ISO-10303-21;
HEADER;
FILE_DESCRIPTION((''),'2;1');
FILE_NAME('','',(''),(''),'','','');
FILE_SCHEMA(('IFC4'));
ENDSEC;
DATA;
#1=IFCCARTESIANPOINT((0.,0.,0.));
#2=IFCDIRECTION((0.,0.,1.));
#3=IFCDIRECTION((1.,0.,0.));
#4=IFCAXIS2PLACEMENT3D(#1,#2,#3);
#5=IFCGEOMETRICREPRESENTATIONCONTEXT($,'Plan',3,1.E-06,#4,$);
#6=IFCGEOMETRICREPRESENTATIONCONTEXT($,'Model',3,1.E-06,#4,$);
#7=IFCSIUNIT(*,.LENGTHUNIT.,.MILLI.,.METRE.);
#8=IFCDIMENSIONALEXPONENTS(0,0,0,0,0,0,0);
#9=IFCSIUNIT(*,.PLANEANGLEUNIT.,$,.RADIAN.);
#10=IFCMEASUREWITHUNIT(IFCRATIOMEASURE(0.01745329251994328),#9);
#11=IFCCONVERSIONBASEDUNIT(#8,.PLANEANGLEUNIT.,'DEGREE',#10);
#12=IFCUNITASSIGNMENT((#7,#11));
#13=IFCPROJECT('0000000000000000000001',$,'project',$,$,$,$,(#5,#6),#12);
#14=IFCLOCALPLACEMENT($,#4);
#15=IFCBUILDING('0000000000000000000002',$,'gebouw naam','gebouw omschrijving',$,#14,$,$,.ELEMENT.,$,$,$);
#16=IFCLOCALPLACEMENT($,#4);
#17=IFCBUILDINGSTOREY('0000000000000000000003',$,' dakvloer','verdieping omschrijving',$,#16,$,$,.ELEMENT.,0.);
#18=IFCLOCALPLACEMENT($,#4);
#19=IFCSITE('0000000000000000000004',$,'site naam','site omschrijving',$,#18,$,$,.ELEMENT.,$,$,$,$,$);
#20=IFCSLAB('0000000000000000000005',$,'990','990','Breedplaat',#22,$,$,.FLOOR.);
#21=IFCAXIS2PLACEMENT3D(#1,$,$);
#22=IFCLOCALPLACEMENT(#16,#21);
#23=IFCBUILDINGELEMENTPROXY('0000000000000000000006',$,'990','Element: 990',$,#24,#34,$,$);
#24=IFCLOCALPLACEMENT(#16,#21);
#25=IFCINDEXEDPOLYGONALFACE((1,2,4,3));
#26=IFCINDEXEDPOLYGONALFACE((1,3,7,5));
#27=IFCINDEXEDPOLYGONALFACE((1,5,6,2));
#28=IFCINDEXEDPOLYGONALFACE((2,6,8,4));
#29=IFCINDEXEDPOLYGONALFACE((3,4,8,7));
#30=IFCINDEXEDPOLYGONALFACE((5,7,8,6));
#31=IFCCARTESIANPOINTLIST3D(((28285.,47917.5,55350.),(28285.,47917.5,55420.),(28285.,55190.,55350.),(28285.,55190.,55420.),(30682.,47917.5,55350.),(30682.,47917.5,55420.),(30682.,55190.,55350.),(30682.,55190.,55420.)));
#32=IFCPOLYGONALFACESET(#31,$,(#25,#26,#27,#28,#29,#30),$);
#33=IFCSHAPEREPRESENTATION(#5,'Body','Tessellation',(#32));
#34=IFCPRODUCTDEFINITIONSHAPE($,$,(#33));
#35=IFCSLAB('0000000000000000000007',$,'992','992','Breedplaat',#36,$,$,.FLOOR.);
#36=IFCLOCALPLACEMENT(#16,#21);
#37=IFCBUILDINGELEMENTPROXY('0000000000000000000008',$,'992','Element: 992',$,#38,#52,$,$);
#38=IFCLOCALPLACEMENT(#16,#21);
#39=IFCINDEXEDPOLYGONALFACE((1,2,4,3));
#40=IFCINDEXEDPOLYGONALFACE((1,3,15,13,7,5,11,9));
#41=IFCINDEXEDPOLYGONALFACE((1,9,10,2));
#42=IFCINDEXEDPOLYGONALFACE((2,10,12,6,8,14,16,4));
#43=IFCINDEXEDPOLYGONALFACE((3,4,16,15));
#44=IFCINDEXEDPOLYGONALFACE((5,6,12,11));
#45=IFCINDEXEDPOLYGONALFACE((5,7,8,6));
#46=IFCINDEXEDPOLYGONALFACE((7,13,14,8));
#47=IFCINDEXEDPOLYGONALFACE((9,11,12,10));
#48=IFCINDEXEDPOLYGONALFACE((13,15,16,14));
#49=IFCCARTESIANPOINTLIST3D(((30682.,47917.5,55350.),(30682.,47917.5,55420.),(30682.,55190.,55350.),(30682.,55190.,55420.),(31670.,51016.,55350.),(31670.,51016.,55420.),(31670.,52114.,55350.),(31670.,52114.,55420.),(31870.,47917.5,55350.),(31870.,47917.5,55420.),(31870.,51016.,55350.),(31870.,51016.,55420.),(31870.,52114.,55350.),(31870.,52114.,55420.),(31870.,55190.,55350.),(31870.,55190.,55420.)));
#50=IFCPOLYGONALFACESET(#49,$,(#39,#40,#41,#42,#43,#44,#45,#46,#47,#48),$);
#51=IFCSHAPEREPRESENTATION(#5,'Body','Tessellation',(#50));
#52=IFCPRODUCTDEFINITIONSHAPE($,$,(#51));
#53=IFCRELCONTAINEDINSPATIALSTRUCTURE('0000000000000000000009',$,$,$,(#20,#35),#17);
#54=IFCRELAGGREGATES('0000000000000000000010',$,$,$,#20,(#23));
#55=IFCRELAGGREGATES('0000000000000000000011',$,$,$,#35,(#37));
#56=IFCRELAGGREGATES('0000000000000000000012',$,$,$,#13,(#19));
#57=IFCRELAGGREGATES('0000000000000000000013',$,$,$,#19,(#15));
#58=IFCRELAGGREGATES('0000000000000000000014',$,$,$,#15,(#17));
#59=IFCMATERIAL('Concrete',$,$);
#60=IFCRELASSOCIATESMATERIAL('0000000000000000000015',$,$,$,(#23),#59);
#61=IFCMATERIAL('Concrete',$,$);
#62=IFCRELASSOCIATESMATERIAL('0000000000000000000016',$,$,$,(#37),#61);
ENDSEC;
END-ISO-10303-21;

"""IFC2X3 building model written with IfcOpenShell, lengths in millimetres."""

from ifc_helpers import new_model, entity, si_unit, converted_unit, frame, origin_with_axes, place, context, project, spatial, polyline, outline, extrude, material, element, aggregate, save


model = new_model("IFC2X3")

# Units and contexts
plan_context = context("Plan", 3, precision=1e-06, world=origin_with_axes())
model_context = context("Model", 3, precision=1e-06, world=origin_with_axes())
ifc_project = project(units=[si_unit("LENGTHUNIT", "METRE", prefix="MILLI"), converted_unit("PLANEANGLEUNIT", "DEGREE", entity("IfcRatioMeasure", 0.01745329251994328), si_unit("PLANEANGLEUNIT", "RADIAN"), dimensions=[0, 0, 0, 0, 0, 0, 0])], contexts=[plan_context, model_context])

# Site, building, storey
site_placement = place(None, origin_with_axes())
site = spatial("IfcSite", under=ifc_project, at=site_placement, Name="site naam", Description="site omschrijving", CompositionType="ELEMENT")
building_placement = place(None, origin_with_axes())
building = spatial("IfcBuilding", under=site, at=building_placement, Name="gebouw naam", Description="gebouw omschrijving", CompositionType="ELEMENT")
storey_placement = place(None, origin_with_axes())
storey = spatial("IfcBuildingStorey", under=building, at=storey_placement, Name=" dakvloer", Description="verdieping omschrijving", CompositionType="ELEMENT", Elevation=0.0)

# Slab, building element proxy, openings
slab_1_placement = place(None, frame((28285.0, 55190.0, 55350.0), z_axis=(0.0, 0.0, 1.0), x_axis=(0.0, -1.0, 0.0)))
slab_1 = element("IfcSlab", 1, at=slab_1_placement, inside=storey, Name="990", Description="990", ObjectType="Breedplaat", PredefinedType="FLOOR")
ifc_material_1 = material(Name="Concrete")
proxy_1_placement = place(slab_1_placement, origin_with_axes())
proxy_1 = element("IfcBuildingElementProxy", 2, at=proxy_1_placement, material=ifc_material_1, Name="990", Description="Element: 990", context=plan_context, shape_type="SweptSolid", body=[
    extrude(outline(polyline([(0.0, 2397.0), (0.0, 0.0), (7272.5, 0.0), (7272.5, 2397.0), (0.0, 2397.0)])), origin_with_axes(), (0.0, 0.0, 1.0), 70.0),
])
opening_1_placement = place(None, frame((28285.0, 55190.0, 55350.0), z_axis=(0.0, 0.0, 1.0), x_axis=(0.0, -1.0, 0.0)))
element("IfcOpeningElement", 3, at=opening_1_placement, cuts=proxy_1, ObjectType="Opening", context=plan_context, shape_type="SweptSolid", body=[
    extrude(outline(polyline([(-0.1, -0.1), (-0.1, 10.0), (10.0, -0.1), (-0.1, -0.1)])), frame((-1.2, -0.1, -0.1), z_axis=(1.0, 0.0, 0.0), x_axis=(0.0, 1.0, 0.0)), (0.0, 0.0, 1.0), 7274.7),
])
opening_2_placement = place(None, frame((28285.0, 55190.0, 55350.0), z_axis=(0.0, 0.0, 1.0), x_axis=(0.0, -1.0, 0.0)))
element("IfcOpeningElement", 4, at=opening_2_placement, cuts=proxy_1, ObjectType="Opening", context=plan_context, shape_type="SweptSolid", body=[
    extrude(outline(polyline([(-0.1, -0.1), (-0.1, 10.0), (10.0, -0.1), (-0.1, -0.1)])), frame((7273.7, 2397.2, -0.1), z_axis=(-1.0, 0.0, 0.0), x_axis=(0.0, -1.0, 0.0)), (0.0, 0.0, 1.0), 7274.7),
])
aggregate(slab_1, [proxy_1])

# Slab, building element proxy, opening
slab_2_placement = place(None, frame((30682.0, 55190.0, 55350.0), z_axis=(0.0, 0.0, 1.0), x_axis=(0.0, -1.0, 0.0)))
slab_2 = element("IfcSlab", 5, at=slab_2_placement, inside=storey, Name="992", Description="992", ObjectType="Breedplaat", PredefinedType="FLOOR")
ifc_material_2 = material(Name="Concrete")
proxy_2_placement = place(slab_2_placement, origin_with_axes())
proxy_2 = element("IfcBuildingElementProxy", 6, at=proxy_2_placement, material=ifc_material_2, Name="992", Description="Element: 992", context=plan_context, shape_type="SweptSolid", body=[
    extrude(outline(polyline([(4174.0, 1188.0), (4174.0, 988.0), (3076.0, 988.0), (3076.0, 1188.0), (0.0, 1188.0), (0.0, 0.0), (7272.5, 0.0), (7272.5, 1188.0), (4174.0, 1188.0)])), origin_with_axes(), (0.0, 0.0, 1.0), 70.0),
])
opening_3_placement = place(None, frame((30682.0, 55190.0, 55350.0), z_axis=(0.0, 0.0, 1.0), x_axis=(0.0, -1.0, 0.0)))
element("IfcOpeningElement", 7, at=opening_3_placement, cuts=proxy_2, ObjectType="Opening", context=plan_context, shape_type="SweptSolid", body=[
    extrude(outline(polyline([(-0.1, -0.1), (-0.1, 10.0), (10.0, -0.1), (-0.1, -0.1)])), frame((-1.2, -0.1, -0.1), z_axis=(1.0, 0.0, 0.0), x_axis=(0.0, 1.0, 0.0)), (0.0, 0.0, 1.0), 7274.7),
])
aggregate(slab_2, [proxy_2])

save(model, "model.ifc")
